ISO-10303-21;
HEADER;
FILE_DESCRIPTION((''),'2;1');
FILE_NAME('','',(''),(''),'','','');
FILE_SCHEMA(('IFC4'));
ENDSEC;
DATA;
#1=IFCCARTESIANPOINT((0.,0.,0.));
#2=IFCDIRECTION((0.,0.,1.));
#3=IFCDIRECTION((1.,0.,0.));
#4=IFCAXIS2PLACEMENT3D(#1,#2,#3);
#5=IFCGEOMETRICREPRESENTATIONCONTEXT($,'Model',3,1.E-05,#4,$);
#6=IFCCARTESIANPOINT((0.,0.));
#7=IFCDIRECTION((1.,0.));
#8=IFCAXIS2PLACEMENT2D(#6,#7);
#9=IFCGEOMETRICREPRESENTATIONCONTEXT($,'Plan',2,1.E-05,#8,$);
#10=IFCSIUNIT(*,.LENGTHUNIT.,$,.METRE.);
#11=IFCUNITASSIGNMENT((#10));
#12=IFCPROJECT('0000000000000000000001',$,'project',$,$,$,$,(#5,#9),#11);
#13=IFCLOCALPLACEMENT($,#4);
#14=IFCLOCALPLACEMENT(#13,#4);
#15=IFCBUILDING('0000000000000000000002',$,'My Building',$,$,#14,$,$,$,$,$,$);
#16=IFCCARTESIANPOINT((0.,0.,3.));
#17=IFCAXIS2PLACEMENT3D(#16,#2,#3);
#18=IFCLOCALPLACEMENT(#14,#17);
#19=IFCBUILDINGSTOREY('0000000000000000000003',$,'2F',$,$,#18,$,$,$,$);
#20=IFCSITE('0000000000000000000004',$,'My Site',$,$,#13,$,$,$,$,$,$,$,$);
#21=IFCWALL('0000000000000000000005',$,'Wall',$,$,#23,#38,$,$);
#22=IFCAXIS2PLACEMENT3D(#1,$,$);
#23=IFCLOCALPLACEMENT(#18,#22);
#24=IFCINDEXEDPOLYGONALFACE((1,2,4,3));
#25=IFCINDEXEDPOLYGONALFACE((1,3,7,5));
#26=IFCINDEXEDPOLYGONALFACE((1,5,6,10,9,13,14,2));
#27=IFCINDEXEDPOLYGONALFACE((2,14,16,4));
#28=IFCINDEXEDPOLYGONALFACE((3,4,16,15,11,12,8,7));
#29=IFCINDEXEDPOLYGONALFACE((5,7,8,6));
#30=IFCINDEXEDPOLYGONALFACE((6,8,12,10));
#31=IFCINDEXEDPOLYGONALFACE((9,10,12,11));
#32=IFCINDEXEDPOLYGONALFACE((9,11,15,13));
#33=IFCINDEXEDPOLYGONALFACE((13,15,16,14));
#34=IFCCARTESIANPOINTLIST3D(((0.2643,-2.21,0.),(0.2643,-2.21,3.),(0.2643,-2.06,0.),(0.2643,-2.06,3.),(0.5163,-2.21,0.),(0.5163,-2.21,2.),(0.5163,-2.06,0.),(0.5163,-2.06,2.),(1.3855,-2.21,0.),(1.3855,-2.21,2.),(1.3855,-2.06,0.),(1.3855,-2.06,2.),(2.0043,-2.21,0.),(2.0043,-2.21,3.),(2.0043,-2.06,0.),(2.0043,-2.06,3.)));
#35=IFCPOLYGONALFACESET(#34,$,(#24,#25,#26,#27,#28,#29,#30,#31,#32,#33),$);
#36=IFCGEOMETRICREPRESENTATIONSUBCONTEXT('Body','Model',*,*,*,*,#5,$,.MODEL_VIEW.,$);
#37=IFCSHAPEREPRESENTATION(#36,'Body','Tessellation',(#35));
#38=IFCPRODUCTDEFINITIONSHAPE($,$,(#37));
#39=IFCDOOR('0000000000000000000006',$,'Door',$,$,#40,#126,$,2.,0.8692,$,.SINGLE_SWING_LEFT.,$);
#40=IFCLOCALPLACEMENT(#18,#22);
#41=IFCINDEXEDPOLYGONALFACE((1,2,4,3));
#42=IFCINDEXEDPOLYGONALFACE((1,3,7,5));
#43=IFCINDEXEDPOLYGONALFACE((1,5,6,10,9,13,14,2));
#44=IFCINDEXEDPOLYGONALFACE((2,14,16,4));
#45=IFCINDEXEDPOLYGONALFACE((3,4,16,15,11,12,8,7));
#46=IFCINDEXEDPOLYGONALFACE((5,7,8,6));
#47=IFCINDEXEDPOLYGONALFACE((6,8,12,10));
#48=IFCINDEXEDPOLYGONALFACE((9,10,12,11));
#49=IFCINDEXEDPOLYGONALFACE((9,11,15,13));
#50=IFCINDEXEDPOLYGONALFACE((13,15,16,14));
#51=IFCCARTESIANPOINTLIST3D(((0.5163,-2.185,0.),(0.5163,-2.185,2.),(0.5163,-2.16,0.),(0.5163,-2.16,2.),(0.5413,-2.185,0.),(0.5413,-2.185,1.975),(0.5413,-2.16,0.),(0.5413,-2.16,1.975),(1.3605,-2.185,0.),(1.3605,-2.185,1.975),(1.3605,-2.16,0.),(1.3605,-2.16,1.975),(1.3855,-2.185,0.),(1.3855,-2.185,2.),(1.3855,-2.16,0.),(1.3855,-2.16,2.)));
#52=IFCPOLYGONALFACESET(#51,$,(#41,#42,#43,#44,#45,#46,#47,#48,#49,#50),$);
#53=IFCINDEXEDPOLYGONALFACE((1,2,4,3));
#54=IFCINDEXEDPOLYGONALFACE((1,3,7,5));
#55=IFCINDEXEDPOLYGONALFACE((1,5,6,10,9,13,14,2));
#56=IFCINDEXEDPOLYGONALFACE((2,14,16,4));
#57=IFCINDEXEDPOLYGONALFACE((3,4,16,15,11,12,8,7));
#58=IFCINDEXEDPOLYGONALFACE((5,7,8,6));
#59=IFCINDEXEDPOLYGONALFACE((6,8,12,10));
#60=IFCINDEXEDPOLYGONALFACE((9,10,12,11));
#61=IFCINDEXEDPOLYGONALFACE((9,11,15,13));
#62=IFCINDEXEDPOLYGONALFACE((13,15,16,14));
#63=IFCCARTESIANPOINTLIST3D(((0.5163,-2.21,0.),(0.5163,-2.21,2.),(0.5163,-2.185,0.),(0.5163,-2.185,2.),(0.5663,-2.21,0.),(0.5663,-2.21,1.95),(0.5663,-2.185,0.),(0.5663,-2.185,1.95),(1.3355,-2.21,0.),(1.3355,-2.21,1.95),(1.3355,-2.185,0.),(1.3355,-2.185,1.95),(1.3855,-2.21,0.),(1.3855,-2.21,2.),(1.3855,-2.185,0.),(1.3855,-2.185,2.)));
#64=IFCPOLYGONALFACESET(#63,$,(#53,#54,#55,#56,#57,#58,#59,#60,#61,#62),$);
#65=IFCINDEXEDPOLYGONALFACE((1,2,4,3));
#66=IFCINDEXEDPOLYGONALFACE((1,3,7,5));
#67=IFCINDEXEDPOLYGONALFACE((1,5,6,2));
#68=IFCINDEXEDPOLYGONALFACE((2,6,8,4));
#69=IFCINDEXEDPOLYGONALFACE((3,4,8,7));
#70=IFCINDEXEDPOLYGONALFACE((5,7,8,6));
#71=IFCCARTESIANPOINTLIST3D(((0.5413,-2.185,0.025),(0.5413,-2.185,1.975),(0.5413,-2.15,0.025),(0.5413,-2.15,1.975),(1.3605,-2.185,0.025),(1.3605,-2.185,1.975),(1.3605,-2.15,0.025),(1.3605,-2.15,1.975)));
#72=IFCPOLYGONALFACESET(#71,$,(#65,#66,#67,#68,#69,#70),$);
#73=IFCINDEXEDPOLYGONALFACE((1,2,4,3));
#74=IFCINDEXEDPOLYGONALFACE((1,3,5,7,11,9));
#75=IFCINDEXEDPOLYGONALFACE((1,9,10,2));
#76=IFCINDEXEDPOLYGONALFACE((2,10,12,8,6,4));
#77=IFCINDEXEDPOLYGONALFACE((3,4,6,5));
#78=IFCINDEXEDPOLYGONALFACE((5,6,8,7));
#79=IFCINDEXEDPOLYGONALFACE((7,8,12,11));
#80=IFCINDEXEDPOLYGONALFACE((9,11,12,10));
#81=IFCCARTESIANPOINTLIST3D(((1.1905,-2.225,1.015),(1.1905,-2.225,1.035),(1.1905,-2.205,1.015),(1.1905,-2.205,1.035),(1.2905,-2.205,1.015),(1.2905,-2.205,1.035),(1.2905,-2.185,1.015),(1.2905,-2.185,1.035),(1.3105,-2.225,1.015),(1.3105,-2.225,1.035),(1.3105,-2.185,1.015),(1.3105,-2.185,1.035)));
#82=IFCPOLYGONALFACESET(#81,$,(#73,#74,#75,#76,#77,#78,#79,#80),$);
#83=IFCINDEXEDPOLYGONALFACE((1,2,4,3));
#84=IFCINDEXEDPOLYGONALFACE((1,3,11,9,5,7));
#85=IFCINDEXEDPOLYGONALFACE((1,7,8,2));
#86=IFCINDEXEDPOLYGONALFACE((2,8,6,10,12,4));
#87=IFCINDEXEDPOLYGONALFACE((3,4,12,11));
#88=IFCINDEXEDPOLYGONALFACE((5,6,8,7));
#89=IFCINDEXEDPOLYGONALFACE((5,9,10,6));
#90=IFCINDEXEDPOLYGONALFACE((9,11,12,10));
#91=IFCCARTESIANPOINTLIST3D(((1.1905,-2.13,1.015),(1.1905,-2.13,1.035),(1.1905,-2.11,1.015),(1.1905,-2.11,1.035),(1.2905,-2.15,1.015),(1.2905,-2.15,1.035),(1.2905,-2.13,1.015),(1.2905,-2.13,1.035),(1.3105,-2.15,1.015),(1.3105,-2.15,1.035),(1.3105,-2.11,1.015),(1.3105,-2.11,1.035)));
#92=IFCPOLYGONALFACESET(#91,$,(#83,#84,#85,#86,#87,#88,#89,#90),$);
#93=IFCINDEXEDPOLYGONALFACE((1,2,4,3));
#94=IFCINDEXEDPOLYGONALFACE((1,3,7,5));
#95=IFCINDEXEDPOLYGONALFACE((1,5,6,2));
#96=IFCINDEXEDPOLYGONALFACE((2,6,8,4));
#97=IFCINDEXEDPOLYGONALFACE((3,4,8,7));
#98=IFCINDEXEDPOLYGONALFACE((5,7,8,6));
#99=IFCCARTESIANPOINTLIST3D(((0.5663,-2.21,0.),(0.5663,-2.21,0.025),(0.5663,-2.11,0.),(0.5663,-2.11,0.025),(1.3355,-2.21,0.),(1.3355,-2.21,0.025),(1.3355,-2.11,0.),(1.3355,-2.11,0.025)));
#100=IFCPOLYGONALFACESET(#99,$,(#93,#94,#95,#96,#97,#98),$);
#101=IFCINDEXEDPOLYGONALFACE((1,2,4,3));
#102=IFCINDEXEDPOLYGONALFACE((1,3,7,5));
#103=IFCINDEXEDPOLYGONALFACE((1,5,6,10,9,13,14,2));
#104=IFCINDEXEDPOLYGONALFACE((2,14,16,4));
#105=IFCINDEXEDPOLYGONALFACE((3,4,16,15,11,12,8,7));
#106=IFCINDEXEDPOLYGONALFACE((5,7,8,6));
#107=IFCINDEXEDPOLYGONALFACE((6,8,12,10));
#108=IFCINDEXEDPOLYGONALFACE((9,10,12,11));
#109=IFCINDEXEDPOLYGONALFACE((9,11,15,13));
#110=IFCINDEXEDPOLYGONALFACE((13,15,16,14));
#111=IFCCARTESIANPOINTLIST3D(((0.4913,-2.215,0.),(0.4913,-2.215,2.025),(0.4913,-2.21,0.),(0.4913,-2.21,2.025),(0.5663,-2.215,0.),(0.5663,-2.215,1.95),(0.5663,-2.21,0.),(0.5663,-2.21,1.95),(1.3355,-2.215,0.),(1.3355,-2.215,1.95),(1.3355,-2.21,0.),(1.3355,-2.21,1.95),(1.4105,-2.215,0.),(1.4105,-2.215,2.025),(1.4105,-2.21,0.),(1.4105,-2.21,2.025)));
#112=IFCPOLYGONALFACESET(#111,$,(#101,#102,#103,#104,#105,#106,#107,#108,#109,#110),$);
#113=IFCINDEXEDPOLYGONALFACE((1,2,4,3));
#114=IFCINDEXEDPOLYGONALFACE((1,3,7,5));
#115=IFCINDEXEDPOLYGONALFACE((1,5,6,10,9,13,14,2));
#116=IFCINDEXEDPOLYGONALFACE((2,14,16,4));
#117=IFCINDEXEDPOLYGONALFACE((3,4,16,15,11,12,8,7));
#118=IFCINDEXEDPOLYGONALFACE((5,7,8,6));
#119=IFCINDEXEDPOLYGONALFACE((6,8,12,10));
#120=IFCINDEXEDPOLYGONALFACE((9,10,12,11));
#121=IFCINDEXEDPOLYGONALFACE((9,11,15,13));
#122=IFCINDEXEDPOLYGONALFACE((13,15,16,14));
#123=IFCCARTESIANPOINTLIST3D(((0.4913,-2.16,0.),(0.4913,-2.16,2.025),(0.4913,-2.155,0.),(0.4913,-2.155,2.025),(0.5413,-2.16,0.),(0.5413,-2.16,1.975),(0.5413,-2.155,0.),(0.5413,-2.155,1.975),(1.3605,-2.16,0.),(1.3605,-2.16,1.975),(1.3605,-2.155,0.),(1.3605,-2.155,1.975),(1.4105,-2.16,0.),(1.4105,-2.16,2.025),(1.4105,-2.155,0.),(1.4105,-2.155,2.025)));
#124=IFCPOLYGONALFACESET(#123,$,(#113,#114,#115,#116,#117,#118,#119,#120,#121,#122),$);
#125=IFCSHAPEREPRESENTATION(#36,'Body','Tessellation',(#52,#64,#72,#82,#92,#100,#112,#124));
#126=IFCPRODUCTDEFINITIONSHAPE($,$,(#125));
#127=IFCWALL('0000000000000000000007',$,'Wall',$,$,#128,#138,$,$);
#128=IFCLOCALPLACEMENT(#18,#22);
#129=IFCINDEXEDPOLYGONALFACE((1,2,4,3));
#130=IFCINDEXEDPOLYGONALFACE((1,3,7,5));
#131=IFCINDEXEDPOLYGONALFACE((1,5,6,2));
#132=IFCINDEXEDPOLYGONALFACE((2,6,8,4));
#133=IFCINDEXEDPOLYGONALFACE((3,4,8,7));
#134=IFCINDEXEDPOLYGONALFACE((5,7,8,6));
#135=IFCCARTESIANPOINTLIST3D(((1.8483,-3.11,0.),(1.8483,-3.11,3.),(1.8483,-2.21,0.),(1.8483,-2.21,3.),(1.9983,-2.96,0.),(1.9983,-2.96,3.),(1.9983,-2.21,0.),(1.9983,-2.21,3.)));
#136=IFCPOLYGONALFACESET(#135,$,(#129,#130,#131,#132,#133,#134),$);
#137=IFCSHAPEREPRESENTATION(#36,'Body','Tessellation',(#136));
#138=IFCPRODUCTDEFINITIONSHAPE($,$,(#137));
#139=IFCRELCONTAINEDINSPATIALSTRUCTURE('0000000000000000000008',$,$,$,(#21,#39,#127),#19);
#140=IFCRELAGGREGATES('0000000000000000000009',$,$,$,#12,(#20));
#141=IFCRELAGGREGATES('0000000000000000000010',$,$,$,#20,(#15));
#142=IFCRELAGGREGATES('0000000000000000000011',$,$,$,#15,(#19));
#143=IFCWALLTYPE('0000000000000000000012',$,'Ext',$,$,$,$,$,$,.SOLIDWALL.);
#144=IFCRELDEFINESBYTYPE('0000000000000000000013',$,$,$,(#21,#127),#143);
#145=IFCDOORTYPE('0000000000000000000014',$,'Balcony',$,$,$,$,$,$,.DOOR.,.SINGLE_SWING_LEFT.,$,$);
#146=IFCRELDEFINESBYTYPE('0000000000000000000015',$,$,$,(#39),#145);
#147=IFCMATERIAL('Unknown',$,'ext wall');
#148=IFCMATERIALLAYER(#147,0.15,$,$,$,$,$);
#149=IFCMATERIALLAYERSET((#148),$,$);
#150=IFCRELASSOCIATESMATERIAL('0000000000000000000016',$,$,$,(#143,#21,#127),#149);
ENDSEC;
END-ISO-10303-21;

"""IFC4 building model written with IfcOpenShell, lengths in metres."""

from ifc_helpers import new_model, entity, si_unit, frame, origin_with_axes, origin_2d_with_axis, place, context, subcontext, project, spatial, line, indexed_curve, outline, extrude, shape, source, transform, mapped, material, layer, layer_set, layer_usage, type_object, type_shapes, element, fill, save


model = new_model("IFC4")

# Units and contexts
model_context = context("Model", 3, precision=1e-05, world=origin_with_axes())
plan_context = context("Plan", 2, precision=1e-05, world=origin_2d_with_axis())
body_context_1 = subcontext(model_context, "Body", "Model", "MODEL_VIEW")
body_context_2 = subcontext(plan_context, "Body", "Plan", "PLAN_VIEW")
ifc_project = project(units=[si_unit("LENGTHUNIT", "METRE")], contexts=[model_context, plan_context])

# Site, building, storey
site_placement = place(None, origin_with_axes())
site = spatial("IfcSite", under=ifc_project, at=site_placement, Name="My Site")
building_placement = place(site_placement, origin_with_axes())
building = spatial("IfcBuilding", under=site, at=building_placement, Name="My Building")
storey_placement = place(building_placement, frame((0.0, 0.0, 3.0), z_axis=(0.0, 0.0, 1.0), x_axis=(1.0, 0.0, 0.0)))
storey = spatial("IfcBuildingStorey", under=building, at=storey_placement, Name="2F")

# Wall, opening, door
ifc_material = material(Name="Unknown", Category="ext wall")
ifc_layer_1 = layer(ifc_material, 0.15)
ifc_layer_set_1 = layer_set([ifc_layer_1])
ifc_layer_usage_1 = layer_usage(ifc_layer_set_1, "AXIS2", "POSITIVE", 0.0)
wall_type_1 = type_object("IfcWallType", Name="Ext", PredefinedType="SOLIDWALL", material=ifc_layer_set_1)
wall_1_placement = place(storey_placement, frame((0.2643, -2.21, 0.0), z_axis=(0.0, 0.0, 1.0), x_axis=(1.0, 0.0, 0.0)))
wall_1 = element("IfcWall", 1, at=wall_1_placement, inside=storey, type_object=wall_type_1, material=ifc_layer_usage_1, Name="Wall", context=body_context_1, shape_type="SweptSolid", body=[
    extrude(outline(indexed_curve([(0.0, 0.0), (0.0, 0.15), (1.74, 0.15), (1.74, 0.0)], segments=[line(1, 2, 3, 4, 1)])), origin_with_axes(), (0.0, 0.0, 1.0), 3.0),
])
shared_shape_1 = source(origin_with_axes(), body_context_1, "Body", "SweptSolid", [
    extrude(outline(indexed_curve([(0.0, 0.0), (0.8692, 0.0), (0.8692, 2.0), (0.0, 2.0)], segments=[line(1, 2, 3, 4, 1)])), frame((0.0, -0.6, 0.0), z_axis=(0.0, -1.0, 0.0), x_axis=(1.0, 0.0, 0.0)), (0.0, 0.0, -1.0), 1.2),
])
opening_1_placement = place(wall_1_placement, frame((0.252, 0.0, 0.0), z_axis=(0.0, 0.0, 1.0), x_axis=(1.0, 0.0, 0.0)))
opening_1 = element("IfcOpeningElement", 2, at=opening_1_placement, cuts=wall_1, PredefinedType="OPENING", context=body_context_1, shape_type="MappedRepresentation", body=[
    mapped(shared_shape_1, transform((0.0, 0.0, 0.0), x_axis=(1.0, 0.0, 0.0), y_axis=(0.0, 1.0, 0.0), z_axis=(0.0, 0.0, 1.0), scale=1.0)),
])
door_type_1 = type_object("IfcDoorType", Name="Balcony", OperationType="SINGLE_SWING_LEFT", PredefinedType="DOOR")
shared_shape_2 = source(origin_with_axes(), body_context_1, "Body", "SweptSolid", [
    extrude(outline(indexed_curve([(0.0, 0.0), (0.0, 2.0), (0.8692, 2.0), (0.8692, 0.0), (0.8442, 0.0), (0.8442, 1.975), (0.025, 1.975), (0.025, 0.0)], segments=[line(1, 2, 3, 4, 5, 6, 7, 8, 1)])), frame((0.0, 0.025, 0.0), z_axis=(0.0, -1.0, 0.0), x_axis=(1.0, 0.0, 0.0)), (0.0, 0.0, -1.0), 0.025),
    extrude(outline(indexed_curve([(0.0, 0.0), (0.0, 2.0), (0.8692, 2.0), (0.8692, 0.0), (0.8192, 0.0), (0.8192, 1.95), (0.05, 1.95), (0.05, 0.0)], segments=[line(1, 2, 3, 4, 5, 6, 7, 8, 1)])), frame((0.0, 0.0, 0.0), z_axis=(0.0, -1.0, 0.0), x_axis=(1.0, 0.0, 0.0)), (0.0, 0.0, -1.0), 0.025),
    extrude(outline(indexed_curve([(0.0, 0.0), (0.8192, 0.0), (0.8192, 0.035), (0.0, 0.035)], segments=[line(1, 2, 3, 4, 1)])), frame((0.025, 0.025, 0.025), z_axis=(0.0, 0.0, 1.0), x_axis=(1.0, 0.0, 0.0)), (0.0, 0.0, 1.0), 1.95),
    extrude(outline(indexed_curve([(0.0, 0.0), (0.0, -0.04), (-0.12, -0.04), (-0.12, -0.02), (-0.02, -0.02), (-0.02, 0.0)], segments=[line(1, 2, 3, 4, 5, 6, 1)])), frame((0.7942, 0.025, 1.015), z_axis=(0.0, 0.0, 1.0), x_axis=(1.0, 0.0, 0.0)), (0.0, 0.0, 1.0), 0.02),
    extrude(outline(indexed_curve([(0.0, 0.0), (0.0, 0.04), (-0.12, 0.04), (-0.12, 0.02), (-0.02, 0.02), (-0.02, 0.0)], segments=[line(1, 2, 3, 4, 5, 6, 1)])), frame((0.7942, 0.06, 1.015), z_axis=(0.0, 0.0, 1.0), x_axis=(1.0, 0.0, 0.0)), (0.0, 0.0, 1.0), 0.02),
    extrude(outline(indexed_curve([(0.0, 0.0), (0.7692, 0.0), (0.7692, 0.1), (0.0, 0.1)], segments=[line(1, 2, 3, 4, 1)])), frame((0.05, 0.0, 0.0), z_axis=(0.0, 0.0, 1.0), x_axis=(1.0, 0.0, 0.0)), (0.0, 0.0, 1.0), 0.025),
    extrude(outline(indexed_curve([(0.0, 0.0), (0.0, 2.025), (0.9192, 2.025), (0.9192, 0.0), (0.8442, 0.0), (0.8442, 1.95), (0.075, 1.95), (0.075, 0.0)], segments=[line(1, 2, 3, 4, 5, 6, 7, 8, 1)])), frame((-0.025, -0.005, 0.0), z_axis=(0.0, -1.0, 0.0), x_axis=(1.0, 0.0, 0.0)), (0.0, 0.0, -1.0), 0.005),
    extrude(outline(indexed_curve([(0.0, 0.0), (0.0, 2.025), (0.9192, 2.025), (0.9192, 0.0), (0.8692, 0.0), (0.8692, 1.975), (0.05, 1.975), (0.05, 0.0)], segments=[line(1, 2, 3, 4, 5, 6, 7, 8, 1)])), frame((-0.025, 0.05, 0.0), z_axis=(0.0, -1.0, 0.0), x_axis=(1.0, 0.0, 0.0)), (0.0, 0.0, -1.0), 0.005),
])
shared_shape_3 = source(origin_with_axes(), body_context_2, "Body", "Curve2D", [
    entity("IfcIndexedPolyCurve", entity("IfcCartesianPointList2D", [[0.0, 0.0], [0.0, 0.05], [0.025, 0.05], [0.025, 0.025], [0.05, 0.025], [0.05, 0.0]]), [entity("IfcLineIndex", [1, 2, 3, 4, 5, 6, 1])]),
    entity("IfcIndexedPolyCurve", entity("IfcCartesianPointList2D", [[0.8692, 0.0], [0.8692, 0.05], [0.8442, 0.05], [0.8442, 0.025], [0.8192, 0.025], [0.8192, 0.0]]), [entity("IfcLineIndex", [1, 2, 3, 4, 5, 6, 1])]),
    entity("IfcTrimmedCurve", entity("IfcEllipse", entity("IfcAxis2Placement2D", entity("IfcCartesianPoint", [0.06, 0.05]), entity("IfcDirection", [1.0, 0.0])), 0.7842, 0.8192), [entity("IfcCartesianPoint", [0.8442, 0.05])], [entity("IfcCartesianPoint", [0.06, 0.8692])], True, "CARTESIAN"),
    entity("IfcIndexedPolyCurve", entity("IfcCartesianPointList2D", [[0.025, 0.05], [0.06, 0.05], [0.06, 0.8692], [0.025, 0.8692]]), [entity("IfcLineIndex", [1, 2, 3, 4, 1])]),
])
type_shapes(door_type_1, [shared_shape_2, shared_shape_3])
door_1_placement = place(opening_1_placement, frame((0.0, 0.0, 0.0), z_axis=(0.0, 0.0, 1.0), x_axis=(1.0, 0.0, 0.0)))
door_1 = element("IfcDoor", 3, at=door_1_placement, inside=storey, type_object=door_type_1, Name="Door", OperationType="SINGLE_SWING_LEFT", OverallHeight=2.0, OverallWidth=0.8692, shapes=[
    shape(body_context_1, "Body", "MappedRepresentation", [mapped(shared_shape_2, transform((0.0, 0.0, 0.0), x_axis=(1.0, 0.0, 0.0), y_axis=(0.0, 1.0, 0.0), z_axis=(0.0, 0.0, 1.0), scale=1.0))]),
    shape(body_context_2, "Body", "MappedRepresentation", [mapped(shared_shape_3, transform((0.0, 0.0, 0.0), x_axis=(1.0, 0.0, 0.0), y_axis=(0.0, 1.0, 0.0), z_axis=(0.0, 0.0, 1.0), scale=1.0))]),
])
fill(opening_1, door_1)

# Wall
ifc_layer_usage_2 = layer_usage(ifc_layer_set_1, "AXIS2", "POSITIVE", 0.0)
wall_2_placement = place(storey_placement, frame((1.8483, -2.21, 0.0), z_axis=(0.0, 0.0, 1.0), x_axis=(0.0, -1.0, 0.0)))
element("IfcWall", 4, at=wall_2_placement, inside=storey, type_object=wall_type_1, material=ifc_layer_usage_2, Name="Wall", context=body_context_1, shape_type="SweptSolid", body=[
    extrude(outline(indexed_curve([(0.0, 0.0), (0.0, 0.15), (0.75, 0.15), (0.9, 0.0)], segments=[line(1, 2, 3, 4, 1)])), origin_with_axes(), (0.0, 0.0, 1.0), 3.0),
])

save(model, "model.ifc")
